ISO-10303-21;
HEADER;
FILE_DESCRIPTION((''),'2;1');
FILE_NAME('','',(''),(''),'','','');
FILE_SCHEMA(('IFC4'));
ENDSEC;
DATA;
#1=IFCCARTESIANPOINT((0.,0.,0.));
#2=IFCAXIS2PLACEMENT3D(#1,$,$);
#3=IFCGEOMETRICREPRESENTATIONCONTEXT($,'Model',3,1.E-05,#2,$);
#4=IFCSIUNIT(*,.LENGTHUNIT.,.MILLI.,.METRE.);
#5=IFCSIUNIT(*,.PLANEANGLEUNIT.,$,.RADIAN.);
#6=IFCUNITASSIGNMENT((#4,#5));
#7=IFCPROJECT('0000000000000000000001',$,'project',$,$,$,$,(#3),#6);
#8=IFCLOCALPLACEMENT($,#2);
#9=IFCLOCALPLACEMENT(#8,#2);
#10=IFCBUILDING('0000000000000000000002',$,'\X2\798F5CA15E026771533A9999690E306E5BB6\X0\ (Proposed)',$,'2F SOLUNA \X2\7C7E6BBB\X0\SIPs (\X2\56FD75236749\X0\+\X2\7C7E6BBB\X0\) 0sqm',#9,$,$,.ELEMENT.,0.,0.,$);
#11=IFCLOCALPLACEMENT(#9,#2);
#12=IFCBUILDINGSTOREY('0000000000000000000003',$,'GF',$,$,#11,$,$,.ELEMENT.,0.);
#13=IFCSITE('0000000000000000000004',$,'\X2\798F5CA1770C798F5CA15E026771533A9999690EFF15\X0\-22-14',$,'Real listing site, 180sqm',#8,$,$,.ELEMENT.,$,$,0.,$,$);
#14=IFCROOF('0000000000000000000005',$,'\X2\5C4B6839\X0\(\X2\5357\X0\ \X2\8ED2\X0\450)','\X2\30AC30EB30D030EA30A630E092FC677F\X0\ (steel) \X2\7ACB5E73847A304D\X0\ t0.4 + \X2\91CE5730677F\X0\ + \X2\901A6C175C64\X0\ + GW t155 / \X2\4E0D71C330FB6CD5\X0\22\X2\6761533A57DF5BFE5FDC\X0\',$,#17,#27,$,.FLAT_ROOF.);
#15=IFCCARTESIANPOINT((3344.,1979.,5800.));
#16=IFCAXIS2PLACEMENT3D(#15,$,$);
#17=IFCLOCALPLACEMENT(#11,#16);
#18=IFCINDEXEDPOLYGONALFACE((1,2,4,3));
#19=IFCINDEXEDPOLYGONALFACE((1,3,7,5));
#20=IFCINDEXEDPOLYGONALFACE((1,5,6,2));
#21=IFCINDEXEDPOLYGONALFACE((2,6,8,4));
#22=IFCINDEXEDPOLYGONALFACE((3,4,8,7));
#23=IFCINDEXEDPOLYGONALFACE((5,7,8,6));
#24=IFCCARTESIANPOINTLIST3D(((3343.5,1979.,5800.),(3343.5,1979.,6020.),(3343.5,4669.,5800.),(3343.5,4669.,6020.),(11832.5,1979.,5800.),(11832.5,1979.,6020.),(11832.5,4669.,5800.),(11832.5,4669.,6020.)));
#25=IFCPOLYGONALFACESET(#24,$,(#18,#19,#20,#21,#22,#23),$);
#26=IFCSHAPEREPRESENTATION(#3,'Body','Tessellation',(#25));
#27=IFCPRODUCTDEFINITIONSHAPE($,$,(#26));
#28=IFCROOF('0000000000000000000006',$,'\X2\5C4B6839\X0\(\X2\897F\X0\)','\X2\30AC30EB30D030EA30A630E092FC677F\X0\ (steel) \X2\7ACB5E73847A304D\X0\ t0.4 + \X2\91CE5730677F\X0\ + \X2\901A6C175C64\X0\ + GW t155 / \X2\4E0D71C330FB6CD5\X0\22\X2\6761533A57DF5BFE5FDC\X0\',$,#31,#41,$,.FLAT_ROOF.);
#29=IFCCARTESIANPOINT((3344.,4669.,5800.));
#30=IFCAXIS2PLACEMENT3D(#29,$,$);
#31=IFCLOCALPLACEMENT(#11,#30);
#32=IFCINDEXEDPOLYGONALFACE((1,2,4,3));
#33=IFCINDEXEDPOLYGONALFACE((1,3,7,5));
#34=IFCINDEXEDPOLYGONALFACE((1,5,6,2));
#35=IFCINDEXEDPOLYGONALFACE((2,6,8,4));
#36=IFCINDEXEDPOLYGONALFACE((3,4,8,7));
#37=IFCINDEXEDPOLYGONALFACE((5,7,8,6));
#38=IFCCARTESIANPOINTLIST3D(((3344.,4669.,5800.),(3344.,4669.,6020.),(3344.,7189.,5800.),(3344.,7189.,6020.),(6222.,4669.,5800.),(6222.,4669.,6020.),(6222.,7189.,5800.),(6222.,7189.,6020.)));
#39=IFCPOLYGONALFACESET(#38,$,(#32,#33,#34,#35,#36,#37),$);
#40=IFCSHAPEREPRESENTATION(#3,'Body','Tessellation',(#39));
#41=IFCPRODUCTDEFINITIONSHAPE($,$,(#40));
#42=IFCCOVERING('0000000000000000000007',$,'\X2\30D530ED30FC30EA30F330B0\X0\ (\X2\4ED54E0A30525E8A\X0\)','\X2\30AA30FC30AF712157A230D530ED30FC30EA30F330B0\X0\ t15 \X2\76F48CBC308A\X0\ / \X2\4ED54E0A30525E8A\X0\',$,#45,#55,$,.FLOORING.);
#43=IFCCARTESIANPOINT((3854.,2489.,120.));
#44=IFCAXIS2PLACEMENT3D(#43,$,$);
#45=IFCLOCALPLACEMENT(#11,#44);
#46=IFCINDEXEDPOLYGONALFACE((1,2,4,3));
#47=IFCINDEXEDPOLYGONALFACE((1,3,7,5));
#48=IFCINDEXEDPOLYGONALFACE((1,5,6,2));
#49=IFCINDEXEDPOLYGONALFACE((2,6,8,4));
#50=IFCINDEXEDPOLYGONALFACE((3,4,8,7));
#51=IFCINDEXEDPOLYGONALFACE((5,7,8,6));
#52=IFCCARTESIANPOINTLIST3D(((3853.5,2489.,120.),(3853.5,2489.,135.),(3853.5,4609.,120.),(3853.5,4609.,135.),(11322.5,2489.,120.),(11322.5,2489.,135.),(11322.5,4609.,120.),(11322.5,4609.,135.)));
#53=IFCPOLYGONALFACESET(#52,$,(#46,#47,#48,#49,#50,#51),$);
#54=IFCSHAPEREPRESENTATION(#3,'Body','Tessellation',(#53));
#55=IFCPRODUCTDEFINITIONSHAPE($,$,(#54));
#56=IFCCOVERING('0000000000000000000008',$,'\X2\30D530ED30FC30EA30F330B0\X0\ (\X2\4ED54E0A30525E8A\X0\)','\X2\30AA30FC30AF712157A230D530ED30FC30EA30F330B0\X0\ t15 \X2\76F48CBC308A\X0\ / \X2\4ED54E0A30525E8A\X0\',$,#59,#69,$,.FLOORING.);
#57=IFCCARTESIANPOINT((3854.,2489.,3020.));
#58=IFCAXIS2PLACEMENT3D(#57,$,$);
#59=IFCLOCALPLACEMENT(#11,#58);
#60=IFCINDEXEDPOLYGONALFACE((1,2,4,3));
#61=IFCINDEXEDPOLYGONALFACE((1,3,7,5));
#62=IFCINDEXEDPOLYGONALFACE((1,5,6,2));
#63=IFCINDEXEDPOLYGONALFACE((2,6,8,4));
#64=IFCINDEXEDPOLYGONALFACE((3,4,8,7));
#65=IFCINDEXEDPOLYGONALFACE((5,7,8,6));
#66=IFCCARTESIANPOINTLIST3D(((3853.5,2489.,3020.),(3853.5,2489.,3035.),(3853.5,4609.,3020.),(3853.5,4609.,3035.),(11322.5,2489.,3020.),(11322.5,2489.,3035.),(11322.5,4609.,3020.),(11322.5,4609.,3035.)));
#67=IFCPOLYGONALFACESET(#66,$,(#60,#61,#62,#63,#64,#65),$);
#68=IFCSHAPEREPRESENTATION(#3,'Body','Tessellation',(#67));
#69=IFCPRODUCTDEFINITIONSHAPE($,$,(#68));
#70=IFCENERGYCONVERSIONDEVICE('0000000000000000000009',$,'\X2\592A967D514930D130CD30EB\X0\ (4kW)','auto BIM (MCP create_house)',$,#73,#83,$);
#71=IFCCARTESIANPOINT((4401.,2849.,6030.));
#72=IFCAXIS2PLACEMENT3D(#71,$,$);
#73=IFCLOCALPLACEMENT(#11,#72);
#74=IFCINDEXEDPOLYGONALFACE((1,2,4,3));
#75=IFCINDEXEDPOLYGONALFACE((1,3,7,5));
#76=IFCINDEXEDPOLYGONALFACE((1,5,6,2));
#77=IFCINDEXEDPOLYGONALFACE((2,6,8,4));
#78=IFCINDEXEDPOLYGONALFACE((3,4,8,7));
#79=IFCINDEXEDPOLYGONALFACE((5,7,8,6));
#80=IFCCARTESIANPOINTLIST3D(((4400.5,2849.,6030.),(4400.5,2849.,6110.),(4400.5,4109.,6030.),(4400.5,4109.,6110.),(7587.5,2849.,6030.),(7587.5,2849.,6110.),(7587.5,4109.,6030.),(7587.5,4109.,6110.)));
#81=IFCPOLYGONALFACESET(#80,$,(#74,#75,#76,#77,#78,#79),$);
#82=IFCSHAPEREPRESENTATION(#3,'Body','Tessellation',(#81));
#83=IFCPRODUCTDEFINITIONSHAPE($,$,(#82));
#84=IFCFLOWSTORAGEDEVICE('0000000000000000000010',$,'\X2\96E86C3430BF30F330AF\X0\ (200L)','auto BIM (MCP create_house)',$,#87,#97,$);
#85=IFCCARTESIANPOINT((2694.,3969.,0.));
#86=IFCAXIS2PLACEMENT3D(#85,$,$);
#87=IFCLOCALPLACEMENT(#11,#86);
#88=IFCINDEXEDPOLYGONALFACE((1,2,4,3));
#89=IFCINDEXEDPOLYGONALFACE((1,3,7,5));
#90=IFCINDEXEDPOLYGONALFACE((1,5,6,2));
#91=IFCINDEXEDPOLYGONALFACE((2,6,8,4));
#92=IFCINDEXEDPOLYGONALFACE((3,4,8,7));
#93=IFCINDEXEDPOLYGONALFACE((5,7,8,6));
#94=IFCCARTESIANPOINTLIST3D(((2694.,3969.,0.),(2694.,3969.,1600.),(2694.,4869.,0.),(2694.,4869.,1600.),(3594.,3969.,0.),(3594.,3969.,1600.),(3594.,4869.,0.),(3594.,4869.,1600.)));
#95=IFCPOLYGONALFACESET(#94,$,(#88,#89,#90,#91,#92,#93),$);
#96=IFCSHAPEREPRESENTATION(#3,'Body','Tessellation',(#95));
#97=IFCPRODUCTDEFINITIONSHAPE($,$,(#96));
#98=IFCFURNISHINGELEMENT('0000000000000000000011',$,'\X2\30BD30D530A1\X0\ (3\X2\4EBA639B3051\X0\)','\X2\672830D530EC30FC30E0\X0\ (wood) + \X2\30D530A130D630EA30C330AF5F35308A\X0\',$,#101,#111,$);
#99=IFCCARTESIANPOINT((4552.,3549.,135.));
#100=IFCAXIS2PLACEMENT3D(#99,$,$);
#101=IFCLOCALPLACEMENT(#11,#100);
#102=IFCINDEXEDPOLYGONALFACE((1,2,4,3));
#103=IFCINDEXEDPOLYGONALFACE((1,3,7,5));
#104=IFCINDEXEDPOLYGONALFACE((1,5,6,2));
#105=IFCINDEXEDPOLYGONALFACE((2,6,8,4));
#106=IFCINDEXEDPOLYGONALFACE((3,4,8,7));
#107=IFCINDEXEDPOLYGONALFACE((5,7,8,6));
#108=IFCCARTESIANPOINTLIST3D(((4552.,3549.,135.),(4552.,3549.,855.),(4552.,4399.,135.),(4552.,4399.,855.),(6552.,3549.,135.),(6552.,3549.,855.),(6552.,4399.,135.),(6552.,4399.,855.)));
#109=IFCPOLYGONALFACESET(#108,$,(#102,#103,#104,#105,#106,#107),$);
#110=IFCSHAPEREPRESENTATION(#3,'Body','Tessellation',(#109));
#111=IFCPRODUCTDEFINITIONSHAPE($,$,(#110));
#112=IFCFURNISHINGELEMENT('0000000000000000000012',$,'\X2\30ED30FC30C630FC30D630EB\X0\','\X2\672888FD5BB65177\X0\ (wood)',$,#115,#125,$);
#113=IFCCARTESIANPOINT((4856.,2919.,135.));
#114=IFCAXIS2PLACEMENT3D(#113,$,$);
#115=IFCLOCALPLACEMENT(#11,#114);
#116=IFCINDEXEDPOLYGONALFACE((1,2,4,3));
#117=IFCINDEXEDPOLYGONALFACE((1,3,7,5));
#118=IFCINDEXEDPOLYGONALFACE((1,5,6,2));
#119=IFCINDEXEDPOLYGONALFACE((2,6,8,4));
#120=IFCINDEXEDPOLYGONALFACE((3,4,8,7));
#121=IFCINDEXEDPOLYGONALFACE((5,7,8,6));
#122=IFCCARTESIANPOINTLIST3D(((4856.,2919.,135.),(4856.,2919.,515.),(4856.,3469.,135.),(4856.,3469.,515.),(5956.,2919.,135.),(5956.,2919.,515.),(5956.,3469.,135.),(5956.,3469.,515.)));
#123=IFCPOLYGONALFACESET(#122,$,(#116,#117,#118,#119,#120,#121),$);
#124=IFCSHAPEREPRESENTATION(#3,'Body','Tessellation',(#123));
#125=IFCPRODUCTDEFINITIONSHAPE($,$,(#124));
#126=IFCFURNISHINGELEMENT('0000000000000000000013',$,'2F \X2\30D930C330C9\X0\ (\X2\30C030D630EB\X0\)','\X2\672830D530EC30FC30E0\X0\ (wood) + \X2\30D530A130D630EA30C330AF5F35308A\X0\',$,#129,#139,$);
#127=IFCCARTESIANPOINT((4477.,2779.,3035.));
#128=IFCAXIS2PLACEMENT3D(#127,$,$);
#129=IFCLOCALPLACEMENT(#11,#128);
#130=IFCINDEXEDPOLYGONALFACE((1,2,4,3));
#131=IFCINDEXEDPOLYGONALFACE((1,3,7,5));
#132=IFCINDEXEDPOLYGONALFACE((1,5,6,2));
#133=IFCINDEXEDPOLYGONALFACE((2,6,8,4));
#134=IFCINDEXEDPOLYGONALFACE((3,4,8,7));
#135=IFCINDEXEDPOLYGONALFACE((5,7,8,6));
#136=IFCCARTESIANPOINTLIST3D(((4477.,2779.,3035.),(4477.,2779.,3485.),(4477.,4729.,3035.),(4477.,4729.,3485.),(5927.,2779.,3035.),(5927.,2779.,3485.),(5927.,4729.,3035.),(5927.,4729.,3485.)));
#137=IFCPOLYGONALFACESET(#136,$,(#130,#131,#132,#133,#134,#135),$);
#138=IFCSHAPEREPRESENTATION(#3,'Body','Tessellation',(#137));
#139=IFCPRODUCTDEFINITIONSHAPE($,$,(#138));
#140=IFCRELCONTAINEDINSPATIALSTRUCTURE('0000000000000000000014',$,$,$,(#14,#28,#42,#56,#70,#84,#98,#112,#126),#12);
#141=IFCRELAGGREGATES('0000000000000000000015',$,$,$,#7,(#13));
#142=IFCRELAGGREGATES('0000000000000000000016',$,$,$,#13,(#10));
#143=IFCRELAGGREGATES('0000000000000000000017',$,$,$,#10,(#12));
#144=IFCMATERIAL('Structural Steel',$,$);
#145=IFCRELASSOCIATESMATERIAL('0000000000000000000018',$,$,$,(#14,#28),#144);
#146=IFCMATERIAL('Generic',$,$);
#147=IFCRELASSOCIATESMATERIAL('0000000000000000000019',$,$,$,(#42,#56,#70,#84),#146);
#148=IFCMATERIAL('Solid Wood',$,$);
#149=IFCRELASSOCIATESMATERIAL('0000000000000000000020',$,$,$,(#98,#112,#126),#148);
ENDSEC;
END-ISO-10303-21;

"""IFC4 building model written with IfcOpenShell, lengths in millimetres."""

from ifc_helpers import new_model, si_unit, frame, frame_2d, origin, place, context, project, spatial, rectangle, extrude, material, element, save


model = new_model("IFC4")

# Units and contexts
model_context = context("Model", 3, precision=1e-05, world=origin())
ifc_project = project(units=[si_unit("LENGTHUNIT", "METRE", prefix="MILLI"), si_unit("PLANEANGLEUNIT", "RADIAN")], contexts=[model_context])

# Site, building, storey
site_placement = place(None, origin())
site = spatial("IfcSite", under=ifc_project, at=site_placement, Name="福岡県福岡市東区香椎５-22-14", ObjectType="Real listing site, 180sqm", CompositionType="ELEMENT", RefElevation=0.0)
building_placement = place(site_placement, origin())
building = spatial("IfcBuilding", under=site, at=building_placement, Name="福岡市東区香椎の家 (Proposed)", ObjectType="2F SOLUNA 籾殻SIPs (国産杉+籾殻) 0sqm", CompositionType="ELEMENT", ElevationOfRefHeight=0.0, ElevationOfTerrain=0.0)
storey_placement = place(building_placement, origin())
storey = spatial("IfcBuildingStorey", under=building, at=storey_placement, Name="GF", CompositionType="ELEMENT", Elevation=0.0)

# Shared definitions
ifc_material_1 = material(Name="Solid Wood")

# Roofs
ifc_material_2 = material(Name="Structural Steel")
roof_1_placement = place(storey_placement, frame((3344.0, 1979.0, 5800.0)))
element("IfcRoof", 1, at=roof_1_placement, inside=storey, material=ifc_material_2, Name="屋根(南 軒450)", Description="ガルバリウム鋼板 (steel) 立平葺き t0.4 + 野地板 + 通気層 + GW t155 / 不燃・法22条区域対応", PredefinedType="FLAT_ROOF", context=model_context, shape_type="SweptSolid", body=[
    extrude(rectangle(XDim=8489.0, YDim=2690.0, at=frame_2d((4244.0, 1345.0))), frame((3344.0, 1979.0, 5800.0)), (0.0, 0.0, 1.0), 220.0),
])
roof_2_placement = place(storey_placement, frame((3344.0, 4669.0, 5800.0)))
element("IfcRoof", 2, at=roof_2_placement, inside=storey, material=ifc_material_2, Name="屋根(西)", Description="ガルバリウム鋼板 (steel) 立平葺き t0.4 + 野地板 + 通気層 + GW t155 / 不燃・法22条区域対応", PredefinedType="FLAT_ROOF", context=model_context, shape_type="SweptSolid", body=[
    extrude(rectangle(XDim=2878.0, YDim=2520.0, at=frame_2d((1439.0, 1260.0))), frame((3344.0, 4669.0, 5800.0)), (0.0, 0.0, 1.0), 220.0),
])

# Coverings
ifc_material_3 = material(Name="Generic")
covering_1_placement = place(storey_placement, frame((3854.0, 2489.0, 120.0)))
element("IfcCovering", 3, at=covering_1_placement, inside=storey, material=ifc_material_3, Name="フローリング (仕上げ床)", Description="オーク無垢フローリング t15 直貼り / 仕上げ床", PredefinedType="FLOORING", context=model_context, shape_type="SweptSolid", body=[
    extrude(rectangle(XDim=7469.0, YDim=2120.0, at=frame_2d((3734.0, 1060.0))), frame((3854.0, 2489.0, 120.0)), (0.0, 0.0, 1.0), 15.0),
])
covering_2_placement = place(storey_placement, frame((3854.0, 2489.0, 3020.0)))
element("IfcCovering", 4, at=covering_2_placement, inside=storey, material=ifc_material_3, Name="フローリング (仕上げ床)", Description="オーク無垢フローリング t15 直貼り / 仕上げ床", PredefinedType="FLOORING", context=model_context, shape_type="SweptSolid", body=[
    extrude(rectangle(XDim=7469.0, YDim=2120.0, at=frame_2d((3734.0, 1060.0))), frame((3854.0, 2489.0, 3020.0)), (0.0, 0.0, 1.0), 15.0),
])

# Energy conversion device
energy_conversion_device_placement = place(storey_placement, frame((4401.0, 2849.0, 6030.0)))
element("IfcEnergyConversionDevice", 5, at=energy_conversion_device_placement, inside=storey, material=ifc_material_3, Name="太陽光パネル (4kW)", Description="auto BIM (MCP create_house)", context=model_context, shape_type="SweptSolid", body=[
    extrude(rectangle(XDim=3187.0, YDim=1260.0, at=frame_2d((1593.0, 630.0))), frame((4401.0, 2849.0, 6030.0)), (0.0, 0.0, 1.0), 80.0),
])

# Flow storage device
flow_storage_device_placement = place(storey_placement, frame((2694.0, 3969.0, 0.0)))
element("IfcFlowStorageDevice", 6, at=flow_storage_device_placement, inside=storey, material=ifc_material_3, Name="雨水タンク (200L)", Description="auto BIM (MCP create_house)", context=model_context, shape_type="SweptSolid", body=[
    extrude(rectangle(XDim=900.0, YDim=900.0, at=frame_2d((450.0, 450.0))), frame((2694.0, 3969.0, 0.0)), (0.0, 0.0, 1.0), 1600.0),
])

# Furnishing elements
furnishing_1_placement = place(storey_placement, frame((4552.0, 3549.0, 135.0)))
element("IfcFurnishingElement", 7, at=furnishing_1_placement, inside=storey, material=ifc_material_1, Name="ソファ (3人掛け)", Description="木フレーム (wood) + ファブリック張り", context=model_context, shape_type="SweptSolid", body=[
    extrude(rectangle(XDim=2000.0, YDim=850.0, at=frame_2d((1000.0, 425.0))), frame((4552.0, 3549.0, 135.0)), (0.0, 0.0, 1.0), 720.0),
])
furnishing_2_placement = place(storey_placement, frame((4856.0, 2919.0, 135.0)))
element("IfcFurnishingElement", 8, at=furnishing_2_placement, inside=storey, material=ifc_material_1, Name="ローテーブル", Description="木製家具 (wood)", context=model_context, shape_type="SweptSolid", body=[
    extrude(rectangle(XDim=1100.0, YDim=550.0, at=frame_2d((550.0, 275.0))), frame((4856.0, 2919.0, 135.0)), (0.0, 0.0, 1.0), 380.0),
])
furnishing_3_placement = place(storey_placement, frame((4477.0, 2779.0, 3035.0)))
element("IfcFurnishingElement", 9, at=furnishing_3_placement, inside=storey, material=ifc_material_1, Name="2F ベッド (ダブル)", Description="木フレーム (wood) + ファブリック張り", context=model_context, shape_type="SweptSolid", body=[
    extrude(rectangle(XDim=1450.0, YDim=1950.0, at=frame_2d((725.0, 975.0))), frame((4477.0, 2779.0, 3035.0)), (0.0, 0.0, 1.0), 450.0),
])

save(model, "model.ifc")
